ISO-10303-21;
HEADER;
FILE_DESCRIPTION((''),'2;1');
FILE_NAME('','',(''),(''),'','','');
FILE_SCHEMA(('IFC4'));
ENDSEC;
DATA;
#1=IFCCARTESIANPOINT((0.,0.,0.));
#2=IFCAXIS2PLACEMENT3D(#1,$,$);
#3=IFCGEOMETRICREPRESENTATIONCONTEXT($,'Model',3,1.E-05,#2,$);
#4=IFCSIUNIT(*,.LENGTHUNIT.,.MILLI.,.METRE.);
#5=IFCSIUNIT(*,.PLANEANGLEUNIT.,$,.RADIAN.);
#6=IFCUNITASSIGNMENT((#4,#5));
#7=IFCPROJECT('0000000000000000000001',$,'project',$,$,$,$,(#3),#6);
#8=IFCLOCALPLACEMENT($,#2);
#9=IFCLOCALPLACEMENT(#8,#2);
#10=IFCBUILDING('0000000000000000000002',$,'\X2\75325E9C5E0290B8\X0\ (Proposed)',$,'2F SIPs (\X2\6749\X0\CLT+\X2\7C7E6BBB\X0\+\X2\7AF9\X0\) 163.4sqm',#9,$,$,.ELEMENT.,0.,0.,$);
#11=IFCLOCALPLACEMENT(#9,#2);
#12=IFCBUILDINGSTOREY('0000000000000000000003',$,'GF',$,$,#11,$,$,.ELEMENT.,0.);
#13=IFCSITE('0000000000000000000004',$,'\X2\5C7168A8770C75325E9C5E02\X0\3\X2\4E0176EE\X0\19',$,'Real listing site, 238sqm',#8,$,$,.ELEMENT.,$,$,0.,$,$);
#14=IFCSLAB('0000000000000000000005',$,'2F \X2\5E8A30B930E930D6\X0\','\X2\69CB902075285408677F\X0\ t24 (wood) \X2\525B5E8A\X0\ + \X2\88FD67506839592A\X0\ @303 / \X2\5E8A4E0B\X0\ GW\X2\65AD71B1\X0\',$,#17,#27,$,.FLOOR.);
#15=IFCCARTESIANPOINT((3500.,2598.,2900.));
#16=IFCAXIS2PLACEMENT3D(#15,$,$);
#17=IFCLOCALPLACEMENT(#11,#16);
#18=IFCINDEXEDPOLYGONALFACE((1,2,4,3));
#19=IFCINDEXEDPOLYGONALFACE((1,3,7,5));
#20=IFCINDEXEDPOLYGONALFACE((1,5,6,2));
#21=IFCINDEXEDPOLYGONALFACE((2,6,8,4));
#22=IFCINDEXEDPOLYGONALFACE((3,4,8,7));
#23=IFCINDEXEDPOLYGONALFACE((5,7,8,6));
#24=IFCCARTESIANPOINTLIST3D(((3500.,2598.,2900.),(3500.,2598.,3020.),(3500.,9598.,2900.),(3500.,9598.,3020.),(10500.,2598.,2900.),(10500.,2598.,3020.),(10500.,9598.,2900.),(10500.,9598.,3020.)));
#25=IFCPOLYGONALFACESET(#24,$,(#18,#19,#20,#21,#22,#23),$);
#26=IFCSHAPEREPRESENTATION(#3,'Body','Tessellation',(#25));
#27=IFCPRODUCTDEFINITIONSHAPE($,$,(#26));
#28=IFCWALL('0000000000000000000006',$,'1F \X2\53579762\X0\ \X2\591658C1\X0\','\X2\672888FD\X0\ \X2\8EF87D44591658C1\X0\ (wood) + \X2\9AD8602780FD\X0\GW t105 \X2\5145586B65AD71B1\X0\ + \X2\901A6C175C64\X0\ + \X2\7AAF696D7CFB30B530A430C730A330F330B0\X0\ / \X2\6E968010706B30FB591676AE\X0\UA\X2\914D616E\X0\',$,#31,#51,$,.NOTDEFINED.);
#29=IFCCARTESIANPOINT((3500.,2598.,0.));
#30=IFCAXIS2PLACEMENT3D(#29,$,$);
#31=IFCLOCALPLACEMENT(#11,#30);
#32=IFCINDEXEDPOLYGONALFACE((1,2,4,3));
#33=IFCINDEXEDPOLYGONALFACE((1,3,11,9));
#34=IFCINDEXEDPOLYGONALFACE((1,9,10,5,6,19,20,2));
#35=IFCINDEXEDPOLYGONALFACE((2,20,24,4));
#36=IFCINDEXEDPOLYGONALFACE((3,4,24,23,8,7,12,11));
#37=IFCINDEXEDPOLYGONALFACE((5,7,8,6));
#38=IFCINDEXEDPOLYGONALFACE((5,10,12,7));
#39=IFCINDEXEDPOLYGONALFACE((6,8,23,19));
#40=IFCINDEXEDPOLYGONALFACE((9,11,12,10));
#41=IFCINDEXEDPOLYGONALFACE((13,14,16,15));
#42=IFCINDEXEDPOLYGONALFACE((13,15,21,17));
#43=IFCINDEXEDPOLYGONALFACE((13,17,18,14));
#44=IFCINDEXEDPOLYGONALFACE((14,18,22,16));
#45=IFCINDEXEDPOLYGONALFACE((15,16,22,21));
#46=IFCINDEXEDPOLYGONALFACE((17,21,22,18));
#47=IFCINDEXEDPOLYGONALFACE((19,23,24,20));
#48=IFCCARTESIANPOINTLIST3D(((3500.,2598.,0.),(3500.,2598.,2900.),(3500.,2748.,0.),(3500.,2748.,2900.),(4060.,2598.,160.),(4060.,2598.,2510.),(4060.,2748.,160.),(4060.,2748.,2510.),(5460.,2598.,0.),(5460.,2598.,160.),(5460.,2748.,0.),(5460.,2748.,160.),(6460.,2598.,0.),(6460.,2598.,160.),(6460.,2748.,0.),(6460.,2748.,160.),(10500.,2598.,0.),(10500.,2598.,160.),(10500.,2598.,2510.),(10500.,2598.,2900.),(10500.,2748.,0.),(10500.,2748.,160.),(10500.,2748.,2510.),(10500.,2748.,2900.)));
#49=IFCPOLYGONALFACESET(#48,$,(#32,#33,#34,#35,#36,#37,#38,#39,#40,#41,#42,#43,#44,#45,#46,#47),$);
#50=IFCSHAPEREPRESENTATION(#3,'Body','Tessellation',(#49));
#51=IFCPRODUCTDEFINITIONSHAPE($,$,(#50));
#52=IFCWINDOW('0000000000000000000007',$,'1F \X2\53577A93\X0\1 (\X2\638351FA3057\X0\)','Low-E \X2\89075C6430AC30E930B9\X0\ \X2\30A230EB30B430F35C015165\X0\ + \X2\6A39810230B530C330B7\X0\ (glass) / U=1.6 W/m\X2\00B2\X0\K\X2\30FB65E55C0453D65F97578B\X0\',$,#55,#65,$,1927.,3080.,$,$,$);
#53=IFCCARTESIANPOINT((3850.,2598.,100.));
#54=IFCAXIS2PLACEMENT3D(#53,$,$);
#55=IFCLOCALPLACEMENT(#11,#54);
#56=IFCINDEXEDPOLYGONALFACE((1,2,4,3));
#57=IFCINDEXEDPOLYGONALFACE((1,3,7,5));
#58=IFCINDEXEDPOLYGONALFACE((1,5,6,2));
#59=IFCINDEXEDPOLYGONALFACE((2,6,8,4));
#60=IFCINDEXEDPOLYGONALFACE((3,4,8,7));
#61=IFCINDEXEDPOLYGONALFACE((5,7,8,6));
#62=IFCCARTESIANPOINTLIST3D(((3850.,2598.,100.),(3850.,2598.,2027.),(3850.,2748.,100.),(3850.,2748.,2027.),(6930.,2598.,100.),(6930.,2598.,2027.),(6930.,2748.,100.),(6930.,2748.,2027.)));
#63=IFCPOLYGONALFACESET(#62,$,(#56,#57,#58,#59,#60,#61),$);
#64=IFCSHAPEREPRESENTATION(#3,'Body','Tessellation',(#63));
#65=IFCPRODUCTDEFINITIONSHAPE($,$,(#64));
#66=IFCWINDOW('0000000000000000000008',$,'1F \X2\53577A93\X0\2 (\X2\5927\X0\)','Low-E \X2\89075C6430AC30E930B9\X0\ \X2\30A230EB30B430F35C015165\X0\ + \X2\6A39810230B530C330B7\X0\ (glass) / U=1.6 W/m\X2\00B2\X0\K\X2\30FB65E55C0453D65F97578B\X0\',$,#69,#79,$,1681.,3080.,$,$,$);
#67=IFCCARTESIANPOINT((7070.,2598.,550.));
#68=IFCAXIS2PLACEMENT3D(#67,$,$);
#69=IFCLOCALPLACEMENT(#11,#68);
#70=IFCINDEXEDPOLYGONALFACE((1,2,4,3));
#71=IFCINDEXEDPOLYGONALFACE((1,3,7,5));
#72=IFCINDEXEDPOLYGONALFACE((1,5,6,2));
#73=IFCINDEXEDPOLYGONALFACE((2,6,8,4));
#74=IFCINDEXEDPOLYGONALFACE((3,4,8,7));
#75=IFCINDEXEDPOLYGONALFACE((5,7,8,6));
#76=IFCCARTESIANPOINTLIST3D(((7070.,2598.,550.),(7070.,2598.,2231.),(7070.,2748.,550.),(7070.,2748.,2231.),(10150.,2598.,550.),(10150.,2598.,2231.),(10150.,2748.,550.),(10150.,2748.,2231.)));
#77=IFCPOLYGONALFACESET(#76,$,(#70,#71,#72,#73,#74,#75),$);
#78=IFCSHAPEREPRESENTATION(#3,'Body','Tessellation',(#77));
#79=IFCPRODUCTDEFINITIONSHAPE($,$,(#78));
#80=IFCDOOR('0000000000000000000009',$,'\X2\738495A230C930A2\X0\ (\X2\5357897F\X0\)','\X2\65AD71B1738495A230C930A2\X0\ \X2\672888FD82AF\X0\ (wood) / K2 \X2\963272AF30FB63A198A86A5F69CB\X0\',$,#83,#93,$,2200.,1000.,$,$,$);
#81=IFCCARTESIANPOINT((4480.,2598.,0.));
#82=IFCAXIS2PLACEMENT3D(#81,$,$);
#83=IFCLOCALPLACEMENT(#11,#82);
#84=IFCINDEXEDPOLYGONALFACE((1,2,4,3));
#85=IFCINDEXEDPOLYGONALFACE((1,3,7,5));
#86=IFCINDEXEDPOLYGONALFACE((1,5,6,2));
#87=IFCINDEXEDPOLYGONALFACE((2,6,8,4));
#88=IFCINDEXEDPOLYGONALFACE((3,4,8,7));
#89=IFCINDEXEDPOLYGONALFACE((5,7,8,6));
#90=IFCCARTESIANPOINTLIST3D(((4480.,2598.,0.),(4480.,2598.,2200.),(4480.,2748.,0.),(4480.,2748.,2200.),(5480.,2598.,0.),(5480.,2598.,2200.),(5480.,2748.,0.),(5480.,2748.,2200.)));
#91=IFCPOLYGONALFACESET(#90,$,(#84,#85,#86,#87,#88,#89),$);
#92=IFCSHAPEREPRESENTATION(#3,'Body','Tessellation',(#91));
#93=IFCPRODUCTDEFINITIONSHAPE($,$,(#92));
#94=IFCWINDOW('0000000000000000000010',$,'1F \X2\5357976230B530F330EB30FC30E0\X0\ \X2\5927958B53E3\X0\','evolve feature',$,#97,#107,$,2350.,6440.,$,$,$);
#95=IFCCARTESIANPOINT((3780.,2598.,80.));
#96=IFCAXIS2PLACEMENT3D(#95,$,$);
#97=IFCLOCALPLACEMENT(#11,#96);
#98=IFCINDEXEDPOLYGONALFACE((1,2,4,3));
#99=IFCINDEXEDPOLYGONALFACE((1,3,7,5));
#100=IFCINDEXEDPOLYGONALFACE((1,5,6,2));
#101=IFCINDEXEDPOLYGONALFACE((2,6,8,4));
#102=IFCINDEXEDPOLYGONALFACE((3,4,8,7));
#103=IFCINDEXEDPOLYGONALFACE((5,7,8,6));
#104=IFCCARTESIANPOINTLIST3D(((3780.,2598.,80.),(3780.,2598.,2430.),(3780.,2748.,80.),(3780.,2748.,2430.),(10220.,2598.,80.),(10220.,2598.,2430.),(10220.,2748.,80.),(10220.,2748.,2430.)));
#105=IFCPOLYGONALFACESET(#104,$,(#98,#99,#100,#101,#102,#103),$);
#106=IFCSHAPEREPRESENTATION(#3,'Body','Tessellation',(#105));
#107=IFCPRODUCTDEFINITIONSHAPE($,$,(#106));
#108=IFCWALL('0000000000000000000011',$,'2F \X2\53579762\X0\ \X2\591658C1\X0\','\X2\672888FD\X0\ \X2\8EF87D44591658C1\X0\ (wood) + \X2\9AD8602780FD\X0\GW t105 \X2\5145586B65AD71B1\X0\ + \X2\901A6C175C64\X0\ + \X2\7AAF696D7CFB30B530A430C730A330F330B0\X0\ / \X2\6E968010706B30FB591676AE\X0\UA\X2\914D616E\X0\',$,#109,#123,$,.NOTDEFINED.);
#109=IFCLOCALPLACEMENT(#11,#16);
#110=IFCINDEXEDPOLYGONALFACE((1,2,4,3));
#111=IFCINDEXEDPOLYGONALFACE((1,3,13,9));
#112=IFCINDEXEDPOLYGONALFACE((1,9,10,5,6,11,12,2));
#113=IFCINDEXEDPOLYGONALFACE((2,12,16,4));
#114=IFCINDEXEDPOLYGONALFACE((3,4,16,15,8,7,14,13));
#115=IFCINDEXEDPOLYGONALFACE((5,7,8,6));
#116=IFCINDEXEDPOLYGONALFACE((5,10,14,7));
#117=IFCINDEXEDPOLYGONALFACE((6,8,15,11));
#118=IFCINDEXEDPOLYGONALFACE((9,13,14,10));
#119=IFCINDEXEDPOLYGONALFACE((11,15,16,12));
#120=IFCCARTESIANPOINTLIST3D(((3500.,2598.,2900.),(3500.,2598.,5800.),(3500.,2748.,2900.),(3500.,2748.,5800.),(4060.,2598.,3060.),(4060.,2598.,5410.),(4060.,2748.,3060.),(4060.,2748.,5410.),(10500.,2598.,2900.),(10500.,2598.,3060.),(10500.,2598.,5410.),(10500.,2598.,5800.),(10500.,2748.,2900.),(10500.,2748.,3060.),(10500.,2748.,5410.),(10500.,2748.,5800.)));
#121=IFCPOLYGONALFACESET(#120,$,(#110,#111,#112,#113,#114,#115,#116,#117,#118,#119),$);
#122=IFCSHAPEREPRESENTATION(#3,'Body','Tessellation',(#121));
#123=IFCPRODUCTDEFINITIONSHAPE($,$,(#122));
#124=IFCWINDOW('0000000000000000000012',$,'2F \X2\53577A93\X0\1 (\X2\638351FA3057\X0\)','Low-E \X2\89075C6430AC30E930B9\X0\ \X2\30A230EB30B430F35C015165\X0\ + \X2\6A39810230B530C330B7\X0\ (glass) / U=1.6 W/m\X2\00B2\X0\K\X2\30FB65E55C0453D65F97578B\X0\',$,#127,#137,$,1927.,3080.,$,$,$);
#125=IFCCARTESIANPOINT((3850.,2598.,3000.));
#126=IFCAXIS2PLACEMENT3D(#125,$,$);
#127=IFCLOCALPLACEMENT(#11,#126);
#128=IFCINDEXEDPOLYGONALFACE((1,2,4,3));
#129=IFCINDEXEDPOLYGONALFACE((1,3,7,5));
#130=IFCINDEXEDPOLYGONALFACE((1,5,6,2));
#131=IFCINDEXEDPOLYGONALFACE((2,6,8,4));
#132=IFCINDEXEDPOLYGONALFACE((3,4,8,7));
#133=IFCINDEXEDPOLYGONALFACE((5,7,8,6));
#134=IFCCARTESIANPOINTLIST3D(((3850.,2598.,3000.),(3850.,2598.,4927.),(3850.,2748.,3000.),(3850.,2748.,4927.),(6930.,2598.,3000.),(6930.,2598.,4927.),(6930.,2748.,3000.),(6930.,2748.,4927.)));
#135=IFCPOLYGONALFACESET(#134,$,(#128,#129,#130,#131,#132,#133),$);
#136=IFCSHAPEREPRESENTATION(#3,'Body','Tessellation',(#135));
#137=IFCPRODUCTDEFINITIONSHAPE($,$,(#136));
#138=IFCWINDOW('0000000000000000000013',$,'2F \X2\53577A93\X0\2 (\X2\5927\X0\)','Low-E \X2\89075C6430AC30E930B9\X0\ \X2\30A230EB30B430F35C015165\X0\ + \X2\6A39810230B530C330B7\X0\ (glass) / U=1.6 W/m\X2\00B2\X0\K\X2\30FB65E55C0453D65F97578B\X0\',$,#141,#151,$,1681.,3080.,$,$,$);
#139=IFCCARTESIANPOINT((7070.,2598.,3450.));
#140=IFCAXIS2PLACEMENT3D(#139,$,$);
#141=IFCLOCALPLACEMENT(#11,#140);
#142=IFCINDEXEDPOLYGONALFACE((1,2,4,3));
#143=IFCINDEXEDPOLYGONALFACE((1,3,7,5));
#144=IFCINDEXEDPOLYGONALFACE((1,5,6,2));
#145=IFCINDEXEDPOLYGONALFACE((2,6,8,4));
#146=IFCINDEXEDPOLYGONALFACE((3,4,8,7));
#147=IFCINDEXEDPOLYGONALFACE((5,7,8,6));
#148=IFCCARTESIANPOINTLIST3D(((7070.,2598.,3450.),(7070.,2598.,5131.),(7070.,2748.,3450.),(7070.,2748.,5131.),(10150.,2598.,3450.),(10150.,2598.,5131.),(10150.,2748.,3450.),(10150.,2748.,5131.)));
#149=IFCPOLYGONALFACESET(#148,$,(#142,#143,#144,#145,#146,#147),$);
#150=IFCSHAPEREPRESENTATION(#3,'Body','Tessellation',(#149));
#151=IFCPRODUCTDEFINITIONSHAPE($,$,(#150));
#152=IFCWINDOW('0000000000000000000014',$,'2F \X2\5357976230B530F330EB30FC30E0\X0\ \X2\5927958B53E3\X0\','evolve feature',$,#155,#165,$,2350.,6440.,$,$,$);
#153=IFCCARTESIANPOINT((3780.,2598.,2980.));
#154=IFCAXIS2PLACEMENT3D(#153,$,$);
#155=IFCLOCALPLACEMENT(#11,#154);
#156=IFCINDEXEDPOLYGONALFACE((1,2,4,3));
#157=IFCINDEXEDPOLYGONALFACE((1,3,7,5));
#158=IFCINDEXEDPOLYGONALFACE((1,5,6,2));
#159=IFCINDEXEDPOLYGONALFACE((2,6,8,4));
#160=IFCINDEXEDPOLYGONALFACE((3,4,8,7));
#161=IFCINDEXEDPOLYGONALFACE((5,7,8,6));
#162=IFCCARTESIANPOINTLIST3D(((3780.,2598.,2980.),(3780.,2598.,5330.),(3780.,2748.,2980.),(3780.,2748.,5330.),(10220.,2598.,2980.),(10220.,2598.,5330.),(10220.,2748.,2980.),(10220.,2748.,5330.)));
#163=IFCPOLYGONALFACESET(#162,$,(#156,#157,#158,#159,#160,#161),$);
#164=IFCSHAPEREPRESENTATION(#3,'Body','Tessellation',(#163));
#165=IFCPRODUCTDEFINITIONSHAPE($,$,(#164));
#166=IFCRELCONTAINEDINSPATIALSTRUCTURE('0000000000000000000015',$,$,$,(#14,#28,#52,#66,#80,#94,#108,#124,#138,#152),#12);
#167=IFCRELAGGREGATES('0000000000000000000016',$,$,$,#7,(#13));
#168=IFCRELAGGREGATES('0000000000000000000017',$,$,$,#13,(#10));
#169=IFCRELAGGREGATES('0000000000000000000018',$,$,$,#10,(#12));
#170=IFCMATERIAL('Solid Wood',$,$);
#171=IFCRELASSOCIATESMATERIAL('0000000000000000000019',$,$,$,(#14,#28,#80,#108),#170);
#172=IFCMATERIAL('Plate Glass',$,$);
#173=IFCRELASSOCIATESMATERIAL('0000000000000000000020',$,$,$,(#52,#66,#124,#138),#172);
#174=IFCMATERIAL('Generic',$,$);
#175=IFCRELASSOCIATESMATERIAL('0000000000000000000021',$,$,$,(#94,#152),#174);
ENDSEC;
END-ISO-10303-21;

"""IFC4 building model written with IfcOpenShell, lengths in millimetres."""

from ifc_helpers import new_model, si_unit, frame, frame_2d, origin, place, context, project, spatial, rectangle, extrude, material, element, fill, save


model = new_model("IFC4")

# Units and contexts
model_context = context("Model", 3, precision=1e-05, world=origin())
ifc_project = project(units=[si_unit("LENGTHUNIT", "METRE", prefix="MILLI"), si_unit("PLANEANGLEUNIT", "RADIAN")], contexts=[model_context])

# Site, building, storey
site_placement = place(None, origin())
site = spatial("IfcSite", under=ifc_project, at=site_placement, Name="山梨県甲府市3丁目19", ObjectType="Real listing site, 238sqm", CompositionType="ELEMENT", RefElevation=0.0)
building_placement = place(site_placement, origin())
building = spatial("IfcBuilding", under=site, at=building_placement, Name="甲府市邸 (Proposed)", ObjectType="2F SIPs (杉CLT+籾殻+竹) 163.4sqm", CompositionType="ELEMENT", ElevationOfRefHeight=0.0, ElevationOfTerrain=0.0)
storey_placement = place(building_placement, origin())
storey = spatial("IfcBuildingStorey", under=building, at=storey_placement, Name="GF", CompositionType="ELEMENT", Elevation=0.0)

# Slab
ifc_material_1 = material(Name="Solid Wood")
slab_1_placement = place(storey_placement, frame((3500.0, 2598.0, 2900.0)))
element("IfcSlab", 1, at=slab_1_placement, inside=storey, material=ifc_material_1, Name="2F 床スラブ", Description="構造用合板 t24 (wood) 剛床 + 製材根太 @303 / 床下 GW断熱", PredefinedType="FLOOR", context=model_context, shape_type="SweptSolid", body=[
    extrude(rectangle(XDim=7000.0, YDim=7000.0, at=frame_2d((3500.0, 3500.0))), frame((3500.0, 2598.0, 2900.0)), (0.0, 0.0, 1.0), 120.0),
])
ifc_material_2 = material(Name="Generic")

# Wall, openings, windows, door
wall_1_placement = place(storey_placement, frame((3500.0, 2598.0, 0.0)))
wall_1 = element("IfcWall", 2, at=wall_1_placement, inside=storey, material=ifc_material_1, Name="1F 南面 外壁", Description="木製 軸組外壁 (wood) + 高性能GW t105 充填断熱 + 通気層 + 窯業系サイディング / 準耐火・外皮UA配慮", PredefinedType="NOTDEFINED", context=model_context, shape_type="SweptSolid", body=[
    extrude(rectangle(XDim=7000.0, YDim=150.0, at=frame_2d((3500.0, 75.0))), frame((3500.0, 2598.0, 0.0)), (0.0, 0.0, 1.0), 2900.0),
])
opening_1_placement = place(storey_placement, frame((3850.0, 2598.0, 100.0)))
opening_1 = element("IfcOpeningElement", 3, at=opening_1_placement, cuts=wall_1, PredefinedType="NOTDEFINED", context=model_context, shape_type="SweptSolid", body=[
    extrude(rectangle(XDim=3080.0, YDim=150.0, at=frame_2d((1540.0, 75.0))), frame((3850.0, 2598.0, 100.0)), (0.0, 0.0, 1.0), 1927.0),
])
opening_2_placement = place(storey_placement, frame((7070.0, 2598.0, 550.0)))
opening_2 = element("IfcOpeningElement", 4, at=opening_2_placement, cuts=wall_1, PredefinedType="NOTDEFINED", context=model_context, shape_type="SweptSolid", body=[
    extrude(rectangle(XDim=3080.0, YDim=150.0, at=frame_2d((1540.0, 75.0))), frame((7070.0, 2598.0, 550.0)), (0.0, 0.0, 1.0), 1681.0),
])
opening_3_placement = place(storey_placement, frame((4480.0, 2598.0, 0.0)))
opening_3 = element("IfcOpeningElement", 5, at=opening_3_placement, cuts=wall_1, PredefinedType="NOTDEFINED", context=model_context, shape_type="SweptSolid", body=[
    extrude(rectangle(XDim=1000.0, YDim=150.0, at=frame_2d((500.0, 75.0))), frame((4480.0, 2598.0, 0.0)), (0.0, 0.0, 1.0), 2200.0),
])
opening_4_placement = place(storey_placement, frame((3780.0, 2598.0, 80.0)))
opening_4 = element("IfcOpeningElement", 6, at=opening_4_placement, cuts=wall_1, PredefinedType="NOTDEFINED", context=model_context, shape_type="SweptSolid", body=[
    extrude(rectangle(XDim=6440.0, YDim=150.0, at=frame_2d((3220.0, 75.0))), frame((3780.0, 2598.0, 80.0)), (0.0, 0.0, 1.0), 2350.0),
])
ifc_material_3 = material(Name="Plate Glass")
window_1_placement = place(storey_placement, frame((3850.0, 2598.0, 100.0)))
window_1 = element("IfcWindow", 7, at=window_1_placement, inside=storey, material=ifc_material_3, Name="1F 南窓1 (掃出し)", Description="Low-E 複層ガラス アルゴン封入 + 樹脂サッシ (glass) / U=1.6 W/m²K・日射取得型", OverallHeight=1927.0, OverallWidth=3080.0, context=model_context, shape_type="SweptSolid", body=[
    extrude(rectangle(XDim=3080.0, YDim=150.0, at=frame_2d((1540.0, 75.0))), frame((3850.0, 2598.0, 100.0)), (0.0, 0.0, 1.0), 1927.0),
])
fill(opening_1, window_1)
window_2_placement = place(storey_placement, frame((7070.0, 2598.0, 550.0)))
window_2 = element("IfcWindow", 8, at=window_2_placement, inside=storey, material=ifc_material_3, Name="1F 南窓2 (大)", Description="Low-E 複層ガラス アルゴン封入 + 樹脂サッシ (glass) / U=1.6 W/m²K・日射取得型", OverallHeight=1681.0, OverallWidth=3080.0, context=model_context, shape_type="SweptSolid", body=[
    extrude(rectangle(XDim=3080.0, YDim=150.0, at=frame_2d((1540.0, 75.0))), frame((7070.0, 2598.0, 550.0)), (0.0, 0.0, 1.0), 1681.0),
])
fill(opening_2, window_2)
door_placement = place(storey_placement, frame((4480.0, 2598.0, 0.0)))
door = element("IfcDoor", 9, at=door_placement, inside=storey, material=ifc_material_1, Name="玄関ドア (南西)", Description="断熱玄関ドア 木製芯 (wood) / K2 防犯・採風機構", OverallHeight=2200.0, OverallWidth=1000.0, context=model_context, shape_type="SweptSolid", body=[
    extrude(rectangle(XDim=1000.0, YDim=150.0, at=frame_2d((500.0, 75.0))), frame((4480.0, 2598.0, 0.0)), (0.0, 0.0, 1.0), 2200.0),
])
fill(opening_3, door)
window_3_placement = place(storey_placement, frame((3780.0, 2598.0, 80.0)))
window_3 = element("IfcWindow", 10, at=window_3_placement, inside=storey, material=ifc_material_2, Name="1F 南面サンルーム 大開口", Description="evolve feature", OverallHeight=2350.0, OverallWidth=6440.0, context=model_context, shape_type="SweptSolid", body=[
    extrude(rectangle(XDim=6440.0, YDim=150.0, at=frame_2d((3220.0, 75.0))), frame((3780.0, 2598.0, 80.0)), (0.0, 0.0, 1.0), 2350.0),
])
fill(opening_4, window_3)

# Wall, openings, windows
wall_2_placement = place(storey_placement, frame((3500.0, 2598.0, 2900.0)))
wall_2 = element("IfcWall", 11, at=wall_2_placement, inside=storey, material=ifc_material_1, Name="2F 南面 外壁", Description="木製 軸組外壁 (wood) + 高性能GW t105 充填断熱 + 通気層 + 窯業系サイディング / 準耐火・外皮UA配慮", PredefinedType="NOTDEFINED", context=model_context, shape_type="SweptSolid", body=[
    extrude(rectangle(XDim=7000.0, YDim=150.0, at=frame_2d((3500.0, 75.0))), frame((3500.0, 2598.0, 2900.0)), (0.0, 0.0, 1.0), 2900.0),
])
opening_5_placement = place(storey_placement, frame((3850.0, 2598.0, 3000.0)))
opening_5 = element("IfcOpeningElement", 12, at=opening_5_placement, cuts=wall_2, PredefinedType="NOTDEFINED", context=model_context, shape_type="SweptSolid", body=[
    extrude(rectangle(XDim=3080.0, YDim=150.0, at=frame_2d((1540.0, 75.0))), frame((3850.0, 2598.0, 3000.0)), (0.0, 0.0, 1.0), 1927.0),
])
opening_6_placement = place(storey_placement, frame((7070.0, 2598.0, 3450.0)))
opening_6 = element("IfcOpeningElement", 13, at=opening_6_placement, cuts=wall_2, PredefinedType="NOTDEFINED", context=model_context, shape_type="SweptSolid", body=[
    extrude(rectangle(XDim=3080.0, YDim=150.0, at=frame_2d((1540.0, 75.0))), frame((7070.0, 2598.0, 3450.0)), (0.0, 0.0, 1.0), 1681.0),
])
opening_7_placement = place(storey_placement, frame((3780.0, 2598.0, 2980.0)))
opening_7 = element("IfcOpeningElement", 14, at=opening_7_placement, cuts=wall_2, PredefinedType="NOTDEFINED", context=model_context, shape_type="SweptSolid", body=[
    extrude(rectangle(XDim=6440.0, YDim=150.0, at=frame_2d((3220.0, 75.0))), frame((3780.0, 2598.0, 2980.0)), (0.0, 0.0, 1.0), 2350.0),
])
window_4_placement = place(storey_placement, frame((3850.0, 2598.0, 3000.0)))
window_4 = element("IfcWindow", 15, at=window_4_placement, inside=storey, material=ifc_material_3, Name="2F 南窓1 (掃出し)", Description="Low-E 複層ガラス アルゴン封入 + 樹脂サッシ (glass) / U=1.6 W/m²K・日射取得型", OverallHeight=1927.0, OverallWidth=3080.0, context=model_context, shape_type="SweptSolid", body=[
    extrude(rectangle(XDim=3080.0, YDim=150.0, at=frame_2d((1540.0, 75.0))), frame((3850.0, 2598.0, 3000.0)), (0.0, 0.0, 1.0), 1927.0),
])
fill(opening_5, window_4)
window_5_placement = place(storey_placement, frame((7070.0, 2598.0, 3450.0)))
window_5 = element("IfcWindow", 16, at=window_5_placement, inside=storey, material=ifc_material_3, Name="2F 南窓2 (大)", Description="Low-E 複層ガラス アルゴン封入 + 樹脂サッシ (glass) / U=1.6 W/m²K・日射取得型", OverallHeight=1681.0, OverallWidth=3080.0, context=model_context, shape_type="SweptSolid", body=[
    extrude(rectangle(XDim=3080.0, YDim=150.0, at=frame_2d((1540.0, 75.0))), frame((7070.0, 2598.0, 3450.0)), (0.0, 0.0, 1.0), 1681.0),
])
fill(opening_6, window_5)
window_6_placement = place(storey_placement, frame((3780.0, 2598.0, 2980.0)))
window_6 = element("IfcWindow", 17, at=window_6_placement, inside=storey, material=ifc_material_2, Name="2F 南面サンルーム 大開口", Description="evolve feature", OverallHeight=2350.0, OverallWidth=6440.0, context=model_context, shape_type="SweptSolid", body=[
    extrude(rectangle(XDim=6440.0, YDim=150.0, at=frame_2d((3220.0, 75.0))), frame((3780.0, 2598.0, 2980.0)), (0.0, 0.0, 1.0), 2350.0),
])
fill(opening_7, window_6)

save(model, "model.ifc")
